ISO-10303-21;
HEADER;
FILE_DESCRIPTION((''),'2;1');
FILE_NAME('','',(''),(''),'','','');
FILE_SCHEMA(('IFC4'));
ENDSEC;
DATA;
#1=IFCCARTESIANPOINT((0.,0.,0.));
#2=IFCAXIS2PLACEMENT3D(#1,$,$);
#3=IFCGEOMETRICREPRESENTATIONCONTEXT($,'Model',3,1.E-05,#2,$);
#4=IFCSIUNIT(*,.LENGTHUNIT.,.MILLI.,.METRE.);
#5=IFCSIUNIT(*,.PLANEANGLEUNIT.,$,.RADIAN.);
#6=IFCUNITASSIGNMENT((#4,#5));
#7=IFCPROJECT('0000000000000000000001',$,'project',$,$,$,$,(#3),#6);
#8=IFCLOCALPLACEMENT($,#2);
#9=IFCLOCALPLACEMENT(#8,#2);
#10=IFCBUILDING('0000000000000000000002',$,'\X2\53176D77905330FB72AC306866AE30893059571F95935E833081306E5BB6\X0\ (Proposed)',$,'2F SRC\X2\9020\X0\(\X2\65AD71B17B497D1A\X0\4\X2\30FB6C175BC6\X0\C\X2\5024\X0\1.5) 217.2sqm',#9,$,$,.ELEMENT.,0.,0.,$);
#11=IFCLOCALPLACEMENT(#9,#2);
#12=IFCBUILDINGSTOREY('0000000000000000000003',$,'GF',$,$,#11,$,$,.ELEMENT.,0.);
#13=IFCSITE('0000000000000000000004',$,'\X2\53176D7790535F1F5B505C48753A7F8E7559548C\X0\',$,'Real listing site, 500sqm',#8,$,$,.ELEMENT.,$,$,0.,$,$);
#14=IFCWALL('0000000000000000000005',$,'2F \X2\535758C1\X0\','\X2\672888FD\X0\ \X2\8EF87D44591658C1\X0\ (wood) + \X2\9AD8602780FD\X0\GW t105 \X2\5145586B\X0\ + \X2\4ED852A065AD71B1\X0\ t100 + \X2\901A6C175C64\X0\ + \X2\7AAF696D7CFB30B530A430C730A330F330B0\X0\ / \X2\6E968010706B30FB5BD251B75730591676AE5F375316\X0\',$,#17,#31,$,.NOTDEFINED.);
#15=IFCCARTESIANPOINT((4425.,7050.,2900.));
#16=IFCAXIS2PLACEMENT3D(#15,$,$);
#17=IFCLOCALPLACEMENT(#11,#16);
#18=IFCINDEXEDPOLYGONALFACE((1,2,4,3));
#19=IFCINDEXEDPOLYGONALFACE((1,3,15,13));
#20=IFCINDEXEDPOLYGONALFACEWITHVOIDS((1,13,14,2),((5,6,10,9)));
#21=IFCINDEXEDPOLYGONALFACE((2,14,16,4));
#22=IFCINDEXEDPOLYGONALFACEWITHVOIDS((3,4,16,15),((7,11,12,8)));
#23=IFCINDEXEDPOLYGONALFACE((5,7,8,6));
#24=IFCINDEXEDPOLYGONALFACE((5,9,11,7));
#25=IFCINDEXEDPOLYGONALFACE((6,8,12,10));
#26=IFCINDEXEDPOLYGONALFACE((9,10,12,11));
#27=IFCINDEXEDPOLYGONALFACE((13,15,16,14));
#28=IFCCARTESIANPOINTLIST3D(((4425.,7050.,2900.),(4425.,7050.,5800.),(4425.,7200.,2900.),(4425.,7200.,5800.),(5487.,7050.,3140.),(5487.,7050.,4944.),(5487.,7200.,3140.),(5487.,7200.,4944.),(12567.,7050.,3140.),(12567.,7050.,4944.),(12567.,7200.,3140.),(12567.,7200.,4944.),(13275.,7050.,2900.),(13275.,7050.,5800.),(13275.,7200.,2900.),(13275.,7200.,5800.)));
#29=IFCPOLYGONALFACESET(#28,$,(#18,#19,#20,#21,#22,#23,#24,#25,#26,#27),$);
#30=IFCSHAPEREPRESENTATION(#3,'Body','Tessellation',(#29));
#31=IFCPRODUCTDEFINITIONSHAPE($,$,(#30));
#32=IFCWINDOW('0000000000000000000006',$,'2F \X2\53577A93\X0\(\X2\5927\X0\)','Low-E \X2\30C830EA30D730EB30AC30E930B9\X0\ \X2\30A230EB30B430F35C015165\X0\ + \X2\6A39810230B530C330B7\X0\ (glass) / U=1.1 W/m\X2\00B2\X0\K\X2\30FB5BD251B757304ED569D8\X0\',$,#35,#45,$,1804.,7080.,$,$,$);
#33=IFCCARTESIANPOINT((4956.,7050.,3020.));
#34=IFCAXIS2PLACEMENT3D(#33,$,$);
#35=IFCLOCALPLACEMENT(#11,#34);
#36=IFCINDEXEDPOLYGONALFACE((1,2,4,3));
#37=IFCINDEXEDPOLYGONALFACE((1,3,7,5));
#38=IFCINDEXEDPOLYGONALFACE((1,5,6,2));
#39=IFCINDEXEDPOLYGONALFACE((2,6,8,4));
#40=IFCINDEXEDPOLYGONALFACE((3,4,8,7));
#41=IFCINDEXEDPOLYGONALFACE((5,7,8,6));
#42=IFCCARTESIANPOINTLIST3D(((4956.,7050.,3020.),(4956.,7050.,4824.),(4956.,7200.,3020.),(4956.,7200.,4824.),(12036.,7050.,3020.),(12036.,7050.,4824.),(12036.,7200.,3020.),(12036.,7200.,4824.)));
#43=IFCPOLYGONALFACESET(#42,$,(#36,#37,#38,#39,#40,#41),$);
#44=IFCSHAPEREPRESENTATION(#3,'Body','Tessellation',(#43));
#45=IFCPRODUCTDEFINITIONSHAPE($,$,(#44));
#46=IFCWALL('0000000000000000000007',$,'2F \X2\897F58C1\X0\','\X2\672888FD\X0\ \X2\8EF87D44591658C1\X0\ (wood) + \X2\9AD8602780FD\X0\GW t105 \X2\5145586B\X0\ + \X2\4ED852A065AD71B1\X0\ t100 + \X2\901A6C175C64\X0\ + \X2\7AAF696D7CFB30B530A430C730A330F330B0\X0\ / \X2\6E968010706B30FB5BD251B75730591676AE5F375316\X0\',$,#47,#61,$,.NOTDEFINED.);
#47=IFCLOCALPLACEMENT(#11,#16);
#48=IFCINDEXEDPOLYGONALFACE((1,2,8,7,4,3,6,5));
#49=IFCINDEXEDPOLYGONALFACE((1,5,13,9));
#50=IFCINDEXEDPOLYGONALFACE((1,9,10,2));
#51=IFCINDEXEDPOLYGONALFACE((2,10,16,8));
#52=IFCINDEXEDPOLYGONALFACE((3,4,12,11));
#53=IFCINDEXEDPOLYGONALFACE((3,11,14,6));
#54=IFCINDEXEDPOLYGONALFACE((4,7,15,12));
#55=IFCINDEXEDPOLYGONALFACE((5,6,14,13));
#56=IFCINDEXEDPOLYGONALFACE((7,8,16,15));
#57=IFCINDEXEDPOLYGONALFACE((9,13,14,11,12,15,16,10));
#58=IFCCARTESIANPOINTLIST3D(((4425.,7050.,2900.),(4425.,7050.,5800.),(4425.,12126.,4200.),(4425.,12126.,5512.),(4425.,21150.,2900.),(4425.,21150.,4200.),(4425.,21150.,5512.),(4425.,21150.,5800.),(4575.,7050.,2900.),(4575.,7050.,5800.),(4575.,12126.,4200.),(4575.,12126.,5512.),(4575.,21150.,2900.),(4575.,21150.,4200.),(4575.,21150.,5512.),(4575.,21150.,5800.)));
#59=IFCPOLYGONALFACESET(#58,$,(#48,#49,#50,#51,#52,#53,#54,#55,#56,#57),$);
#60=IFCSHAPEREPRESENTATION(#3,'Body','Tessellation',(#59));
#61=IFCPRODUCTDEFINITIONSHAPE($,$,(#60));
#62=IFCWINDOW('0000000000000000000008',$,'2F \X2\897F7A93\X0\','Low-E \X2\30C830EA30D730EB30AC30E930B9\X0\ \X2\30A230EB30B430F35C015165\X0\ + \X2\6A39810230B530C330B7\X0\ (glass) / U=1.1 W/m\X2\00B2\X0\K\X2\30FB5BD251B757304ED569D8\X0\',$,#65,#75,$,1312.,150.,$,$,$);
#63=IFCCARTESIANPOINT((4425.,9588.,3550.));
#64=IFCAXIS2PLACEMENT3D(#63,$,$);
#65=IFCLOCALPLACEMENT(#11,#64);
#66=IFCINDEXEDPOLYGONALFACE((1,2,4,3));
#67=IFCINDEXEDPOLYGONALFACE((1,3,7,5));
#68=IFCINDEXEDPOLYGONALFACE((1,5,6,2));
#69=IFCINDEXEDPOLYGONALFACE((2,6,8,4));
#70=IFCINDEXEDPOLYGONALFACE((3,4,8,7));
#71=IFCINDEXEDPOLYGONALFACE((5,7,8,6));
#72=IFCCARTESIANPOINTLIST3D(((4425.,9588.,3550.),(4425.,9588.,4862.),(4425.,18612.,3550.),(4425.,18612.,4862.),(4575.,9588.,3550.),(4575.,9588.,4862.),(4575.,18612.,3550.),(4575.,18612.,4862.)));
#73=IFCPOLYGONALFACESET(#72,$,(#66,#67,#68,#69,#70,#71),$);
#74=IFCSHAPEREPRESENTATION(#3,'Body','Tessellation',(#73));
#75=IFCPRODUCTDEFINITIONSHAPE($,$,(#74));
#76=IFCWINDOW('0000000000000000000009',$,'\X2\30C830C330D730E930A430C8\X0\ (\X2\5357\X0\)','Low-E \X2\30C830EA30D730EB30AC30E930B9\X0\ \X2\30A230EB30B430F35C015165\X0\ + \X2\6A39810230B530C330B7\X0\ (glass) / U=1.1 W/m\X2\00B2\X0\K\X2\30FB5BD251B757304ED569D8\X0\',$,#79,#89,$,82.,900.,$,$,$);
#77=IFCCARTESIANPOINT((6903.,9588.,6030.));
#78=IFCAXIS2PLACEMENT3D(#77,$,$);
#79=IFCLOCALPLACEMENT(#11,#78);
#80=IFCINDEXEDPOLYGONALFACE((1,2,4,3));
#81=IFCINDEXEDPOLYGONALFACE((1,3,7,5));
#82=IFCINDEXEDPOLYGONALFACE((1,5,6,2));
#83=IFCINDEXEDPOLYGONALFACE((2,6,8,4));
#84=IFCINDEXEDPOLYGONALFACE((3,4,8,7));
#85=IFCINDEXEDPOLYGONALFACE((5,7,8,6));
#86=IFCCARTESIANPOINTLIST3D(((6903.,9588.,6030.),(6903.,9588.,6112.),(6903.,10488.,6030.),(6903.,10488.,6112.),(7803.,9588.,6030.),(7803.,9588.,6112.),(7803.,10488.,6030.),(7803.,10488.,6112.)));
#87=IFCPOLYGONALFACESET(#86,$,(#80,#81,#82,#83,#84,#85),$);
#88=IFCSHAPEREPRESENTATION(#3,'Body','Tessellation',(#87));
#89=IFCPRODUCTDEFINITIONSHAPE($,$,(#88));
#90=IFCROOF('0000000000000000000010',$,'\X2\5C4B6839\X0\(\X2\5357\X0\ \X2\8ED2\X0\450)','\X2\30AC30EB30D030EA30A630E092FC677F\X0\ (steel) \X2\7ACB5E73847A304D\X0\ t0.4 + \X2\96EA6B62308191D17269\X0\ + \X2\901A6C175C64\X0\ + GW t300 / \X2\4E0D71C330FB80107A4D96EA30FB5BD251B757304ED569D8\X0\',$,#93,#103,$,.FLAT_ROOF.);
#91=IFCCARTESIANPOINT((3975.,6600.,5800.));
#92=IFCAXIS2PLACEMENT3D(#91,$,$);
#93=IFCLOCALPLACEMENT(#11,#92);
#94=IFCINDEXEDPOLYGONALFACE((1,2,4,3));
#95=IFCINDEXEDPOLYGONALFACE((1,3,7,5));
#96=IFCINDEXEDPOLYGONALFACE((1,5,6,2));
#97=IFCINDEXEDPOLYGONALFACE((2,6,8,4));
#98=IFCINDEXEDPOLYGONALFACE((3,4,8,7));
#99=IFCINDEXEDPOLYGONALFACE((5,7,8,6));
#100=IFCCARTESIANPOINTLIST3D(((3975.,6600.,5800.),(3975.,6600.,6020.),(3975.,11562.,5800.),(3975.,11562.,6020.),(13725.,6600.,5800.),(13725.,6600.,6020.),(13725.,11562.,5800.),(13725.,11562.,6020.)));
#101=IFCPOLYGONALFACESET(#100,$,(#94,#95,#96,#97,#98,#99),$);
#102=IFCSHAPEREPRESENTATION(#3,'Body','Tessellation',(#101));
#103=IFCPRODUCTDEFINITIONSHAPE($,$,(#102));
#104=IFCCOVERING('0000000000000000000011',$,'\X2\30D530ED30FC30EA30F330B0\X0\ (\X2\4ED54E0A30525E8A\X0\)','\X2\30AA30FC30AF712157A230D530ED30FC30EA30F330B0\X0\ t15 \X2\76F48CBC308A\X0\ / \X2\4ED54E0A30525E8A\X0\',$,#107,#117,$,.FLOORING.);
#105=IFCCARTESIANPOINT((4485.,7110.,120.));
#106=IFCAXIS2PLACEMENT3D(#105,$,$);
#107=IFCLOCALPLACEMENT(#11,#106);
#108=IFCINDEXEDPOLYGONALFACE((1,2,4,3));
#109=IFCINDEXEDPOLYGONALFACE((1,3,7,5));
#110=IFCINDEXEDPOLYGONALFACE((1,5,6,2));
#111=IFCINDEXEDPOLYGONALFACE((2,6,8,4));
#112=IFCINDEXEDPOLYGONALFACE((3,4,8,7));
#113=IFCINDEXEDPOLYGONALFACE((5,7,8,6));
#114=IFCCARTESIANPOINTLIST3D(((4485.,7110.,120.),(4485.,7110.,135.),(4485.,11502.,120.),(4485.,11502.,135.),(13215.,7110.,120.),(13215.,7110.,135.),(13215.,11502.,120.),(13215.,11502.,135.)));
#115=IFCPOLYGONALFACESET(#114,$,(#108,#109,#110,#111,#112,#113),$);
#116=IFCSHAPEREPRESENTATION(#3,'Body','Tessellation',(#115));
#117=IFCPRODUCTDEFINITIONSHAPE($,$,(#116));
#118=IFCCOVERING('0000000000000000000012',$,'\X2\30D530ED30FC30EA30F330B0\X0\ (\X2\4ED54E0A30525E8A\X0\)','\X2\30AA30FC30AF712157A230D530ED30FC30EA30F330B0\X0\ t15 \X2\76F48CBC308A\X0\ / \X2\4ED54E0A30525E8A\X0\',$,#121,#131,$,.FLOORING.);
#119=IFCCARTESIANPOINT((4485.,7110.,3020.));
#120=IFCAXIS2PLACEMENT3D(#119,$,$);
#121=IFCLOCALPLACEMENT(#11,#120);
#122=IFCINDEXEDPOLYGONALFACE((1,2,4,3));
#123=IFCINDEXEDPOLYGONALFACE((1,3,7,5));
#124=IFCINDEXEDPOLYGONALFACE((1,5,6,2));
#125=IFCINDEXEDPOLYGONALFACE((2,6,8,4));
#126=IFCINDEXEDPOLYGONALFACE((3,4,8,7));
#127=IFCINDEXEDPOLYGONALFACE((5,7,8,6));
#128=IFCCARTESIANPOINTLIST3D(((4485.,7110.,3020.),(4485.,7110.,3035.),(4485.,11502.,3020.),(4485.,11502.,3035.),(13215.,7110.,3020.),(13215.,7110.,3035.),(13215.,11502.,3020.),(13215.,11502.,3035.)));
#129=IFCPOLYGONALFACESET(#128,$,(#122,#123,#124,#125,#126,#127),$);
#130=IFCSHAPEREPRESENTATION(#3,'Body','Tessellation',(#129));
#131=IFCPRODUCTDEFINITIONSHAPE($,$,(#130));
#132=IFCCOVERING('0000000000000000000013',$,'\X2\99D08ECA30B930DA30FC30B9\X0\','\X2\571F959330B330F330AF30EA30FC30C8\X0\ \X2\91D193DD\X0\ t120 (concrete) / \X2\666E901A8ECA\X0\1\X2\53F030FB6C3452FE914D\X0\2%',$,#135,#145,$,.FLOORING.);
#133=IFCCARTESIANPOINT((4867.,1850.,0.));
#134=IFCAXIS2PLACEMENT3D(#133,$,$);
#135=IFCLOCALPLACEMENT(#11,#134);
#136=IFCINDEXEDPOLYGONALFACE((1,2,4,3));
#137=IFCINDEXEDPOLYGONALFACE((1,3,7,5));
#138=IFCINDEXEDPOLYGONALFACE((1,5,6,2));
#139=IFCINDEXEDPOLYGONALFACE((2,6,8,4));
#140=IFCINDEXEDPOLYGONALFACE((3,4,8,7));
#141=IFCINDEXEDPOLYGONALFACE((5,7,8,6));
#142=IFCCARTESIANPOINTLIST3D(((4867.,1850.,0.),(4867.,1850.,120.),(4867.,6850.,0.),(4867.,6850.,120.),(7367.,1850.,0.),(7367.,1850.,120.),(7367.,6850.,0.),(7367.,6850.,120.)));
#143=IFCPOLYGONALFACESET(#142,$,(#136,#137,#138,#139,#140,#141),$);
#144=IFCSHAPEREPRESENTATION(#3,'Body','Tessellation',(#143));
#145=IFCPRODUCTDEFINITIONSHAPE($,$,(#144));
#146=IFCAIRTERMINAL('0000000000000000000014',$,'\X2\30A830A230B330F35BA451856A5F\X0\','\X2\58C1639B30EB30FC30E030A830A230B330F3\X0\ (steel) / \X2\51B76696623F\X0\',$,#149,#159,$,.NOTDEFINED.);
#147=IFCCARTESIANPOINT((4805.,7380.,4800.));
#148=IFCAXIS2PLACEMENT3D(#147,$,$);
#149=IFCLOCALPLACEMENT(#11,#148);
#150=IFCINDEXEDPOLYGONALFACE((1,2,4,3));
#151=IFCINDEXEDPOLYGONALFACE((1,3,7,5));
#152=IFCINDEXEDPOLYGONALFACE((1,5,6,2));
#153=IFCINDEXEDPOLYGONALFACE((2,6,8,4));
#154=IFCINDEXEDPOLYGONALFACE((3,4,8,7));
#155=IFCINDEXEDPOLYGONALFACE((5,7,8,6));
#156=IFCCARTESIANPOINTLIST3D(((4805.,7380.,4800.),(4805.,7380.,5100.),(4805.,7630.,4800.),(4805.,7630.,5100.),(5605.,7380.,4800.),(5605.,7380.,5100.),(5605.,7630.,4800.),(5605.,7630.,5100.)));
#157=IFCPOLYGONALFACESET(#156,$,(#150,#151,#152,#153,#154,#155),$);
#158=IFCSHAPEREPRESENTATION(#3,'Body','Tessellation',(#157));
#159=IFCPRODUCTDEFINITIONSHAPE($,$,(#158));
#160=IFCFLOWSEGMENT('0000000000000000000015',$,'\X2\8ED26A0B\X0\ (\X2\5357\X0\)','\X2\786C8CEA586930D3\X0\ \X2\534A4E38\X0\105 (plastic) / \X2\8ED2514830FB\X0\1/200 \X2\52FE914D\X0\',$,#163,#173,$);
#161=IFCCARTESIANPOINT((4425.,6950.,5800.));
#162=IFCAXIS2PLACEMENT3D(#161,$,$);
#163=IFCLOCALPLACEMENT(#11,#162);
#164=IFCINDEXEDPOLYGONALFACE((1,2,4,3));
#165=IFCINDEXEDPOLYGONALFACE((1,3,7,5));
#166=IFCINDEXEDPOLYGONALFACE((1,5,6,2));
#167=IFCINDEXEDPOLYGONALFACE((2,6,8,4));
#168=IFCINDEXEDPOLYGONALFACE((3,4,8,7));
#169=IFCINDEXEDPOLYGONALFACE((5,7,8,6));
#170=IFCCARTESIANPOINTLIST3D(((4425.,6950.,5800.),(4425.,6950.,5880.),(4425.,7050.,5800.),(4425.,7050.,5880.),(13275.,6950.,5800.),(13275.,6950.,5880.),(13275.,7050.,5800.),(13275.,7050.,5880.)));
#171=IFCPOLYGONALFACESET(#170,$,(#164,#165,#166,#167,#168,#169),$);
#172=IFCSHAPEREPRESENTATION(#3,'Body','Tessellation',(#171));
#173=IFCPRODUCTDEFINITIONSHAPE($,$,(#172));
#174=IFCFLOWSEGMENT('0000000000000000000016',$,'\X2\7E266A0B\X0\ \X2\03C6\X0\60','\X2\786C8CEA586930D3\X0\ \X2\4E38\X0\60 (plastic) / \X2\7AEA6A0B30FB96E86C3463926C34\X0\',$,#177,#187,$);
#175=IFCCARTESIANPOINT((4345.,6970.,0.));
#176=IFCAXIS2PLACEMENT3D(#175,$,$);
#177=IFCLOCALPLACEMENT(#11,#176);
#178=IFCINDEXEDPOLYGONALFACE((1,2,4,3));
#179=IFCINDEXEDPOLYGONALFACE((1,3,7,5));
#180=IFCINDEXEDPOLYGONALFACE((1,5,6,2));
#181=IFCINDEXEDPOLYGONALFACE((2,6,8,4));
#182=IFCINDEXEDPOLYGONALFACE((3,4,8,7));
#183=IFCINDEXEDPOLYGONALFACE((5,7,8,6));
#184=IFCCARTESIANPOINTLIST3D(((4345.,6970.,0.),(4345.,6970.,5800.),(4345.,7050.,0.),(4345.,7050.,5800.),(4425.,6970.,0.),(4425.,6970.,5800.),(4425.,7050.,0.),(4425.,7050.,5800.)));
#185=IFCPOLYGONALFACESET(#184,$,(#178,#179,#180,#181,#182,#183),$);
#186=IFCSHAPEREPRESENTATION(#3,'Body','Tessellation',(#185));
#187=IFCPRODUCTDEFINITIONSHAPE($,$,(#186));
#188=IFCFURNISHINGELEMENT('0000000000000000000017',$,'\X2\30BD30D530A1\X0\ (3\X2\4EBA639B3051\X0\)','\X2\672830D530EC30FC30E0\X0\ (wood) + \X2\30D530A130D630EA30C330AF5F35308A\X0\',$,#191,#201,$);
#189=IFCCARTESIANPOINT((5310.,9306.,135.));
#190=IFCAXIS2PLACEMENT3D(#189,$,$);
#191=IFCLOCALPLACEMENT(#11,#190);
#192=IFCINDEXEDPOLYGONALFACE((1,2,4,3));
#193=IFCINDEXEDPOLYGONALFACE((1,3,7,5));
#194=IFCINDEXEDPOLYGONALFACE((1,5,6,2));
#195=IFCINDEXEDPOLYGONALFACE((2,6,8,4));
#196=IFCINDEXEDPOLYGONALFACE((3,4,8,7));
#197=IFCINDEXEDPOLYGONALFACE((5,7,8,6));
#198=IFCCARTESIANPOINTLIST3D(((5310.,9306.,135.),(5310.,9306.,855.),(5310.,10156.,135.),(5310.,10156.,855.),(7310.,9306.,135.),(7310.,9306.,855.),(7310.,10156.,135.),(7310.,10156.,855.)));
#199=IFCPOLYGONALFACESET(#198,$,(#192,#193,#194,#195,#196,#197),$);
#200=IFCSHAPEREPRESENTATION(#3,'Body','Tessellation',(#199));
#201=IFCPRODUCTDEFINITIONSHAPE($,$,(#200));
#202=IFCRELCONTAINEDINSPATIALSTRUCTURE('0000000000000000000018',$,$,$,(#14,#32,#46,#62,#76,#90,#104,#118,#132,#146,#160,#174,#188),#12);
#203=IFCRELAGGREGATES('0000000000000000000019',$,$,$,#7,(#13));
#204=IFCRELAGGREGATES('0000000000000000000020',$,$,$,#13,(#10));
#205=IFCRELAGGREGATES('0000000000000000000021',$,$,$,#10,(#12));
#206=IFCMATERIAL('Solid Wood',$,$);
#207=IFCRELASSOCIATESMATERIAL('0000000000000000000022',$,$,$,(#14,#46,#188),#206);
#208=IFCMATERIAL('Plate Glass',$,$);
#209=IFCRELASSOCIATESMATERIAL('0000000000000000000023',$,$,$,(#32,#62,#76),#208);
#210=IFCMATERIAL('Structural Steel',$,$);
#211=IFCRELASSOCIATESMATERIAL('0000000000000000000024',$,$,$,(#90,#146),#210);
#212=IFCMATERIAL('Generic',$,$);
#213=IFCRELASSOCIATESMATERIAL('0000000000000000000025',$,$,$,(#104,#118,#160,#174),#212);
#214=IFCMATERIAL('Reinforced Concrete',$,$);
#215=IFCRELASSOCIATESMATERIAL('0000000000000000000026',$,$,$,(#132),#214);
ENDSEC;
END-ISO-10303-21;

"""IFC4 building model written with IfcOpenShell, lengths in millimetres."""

from ifc_helpers import new_model, si_unit, frame, frame_2d, origin, place, context, project, spatial, rectangle, extrude, material, element, fill, save


model = new_model("IFC4")

# Units and contexts
model_context = context("Model", 3, precision=1e-05, world=origin())
ifc_project = project(units=[si_unit("LENGTHUNIT", "METRE", prefix="MILLI"), si_unit("PLANEANGLEUNIT", "RADIAN")], contexts=[model_context])

# Site, building, storey
site_placement = place(None, origin())
site = spatial("IfcSite", under=ifc_project, at=site_placement, Name="北海道弟子屈町美留和", ObjectType="Real listing site, 500sqm", CompositionType="ELEMENT", RefElevation=0.0)
building_placement = place(site_placement, origin())
building = spatial("IfcBuilding", under=site, at=building_placement, Name="北海道・犬と暮らす土間広めの家 (Proposed)", ObjectType="2F SRC造(断熱等級4・気密C値1.5) 217.2sqm", CompositionType="ELEMENT", ElevationOfRefHeight=0.0, ElevationOfTerrain=0.0)
storey_placement = place(building_placement, origin())
storey = spatial("IfcBuildingStorey", under=building, at=storey_placement, Name="GF", CompositionType="ELEMENT", Elevation=0.0)

# Shared definitions
ifc_material_1 = material(Name="Solid Wood")

# Shared definitions
ifc_material_2 = material(Name="Reinforced Concrete")

# Shared definitions
ifc_material_3 = material(Name="Plate Glass")

# Walls, openings, windows
wall_1_placement = place(storey_placement, frame((4425.0, 7050.0, 2900.0)))
wall_1 = element("IfcWall", 1, at=wall_1_placement, inside=storey, material=ifc_material_1, Name="2F 南壁", Description="木製 軸組外壁 (wood) + 高性能GW t105 充填 + 付加断熱 t100 + 通気層 + 窯業系サイディング / 準耐火・寒冷地外皮強化", PredefinedType="NOTDEFINED", context=model_context, shape_type="SweptSolid", body=[
    extrude(rectangle(XDim=8850.0, YDim=150.0, at=frame_2d((4425.0, 75.0))), frame((4425.0, 7050.0, 2900.0)), (0.0, 0.0, 1.0), 2900.0),
])
opening_1_placement = place(storey_placement, frame((4956.0, 7050.0, 3020.0)))
opening_1 = element("IfcOpeningElement", 2, at=opening_1_placement, cuts=wall_1, PredefinedType="NOTDEFINED", context=model_context, shape_type="SweptSolid", body=[
    extrude(rectangle(XDim=7080.0, YDim=150.0, at=frame_2d((3540.0, 75.0))), frame((4956.0, 7050.0, 3020.0)), (0.0, 0.0, 1.0), 1804.0),
])
window_1_placement = place(storey_placement, frame((4956.0, 7050.0, 3020.0)))
window_1 = element("IfcWindow", 3, at=window_1_placement, inside=storey, material=ifc_material_3, Name="2F 南窓(大)", Description="Low-E トリプルガラス アルゴン封入 + 樹脂サッシ (glass) / U=1.1 W/m²K・寒冷地仕様", OverallHeight=1804.0, OverallWidth=7080.0, context=model_context, shape_type="SweptSolid", body=[
    extrude(rectangle(XDim=7080.0, YDim=150.0, at=frame_2d((3540.0, 75.0))), frame((4956.0, 7050.0, 3020.0)), (0.0, 0.0, 1.0), 1804.0),
])
fill(opening_1, window_1)
wall_2_placement = place(storey_placement, frame((4425.0, 7050.0, 2900.0)))
wall_2 = element("IfcWall", 4, at=wall_2_placement, inside=storey, material=ifc_material_1, Name="2F 西壁", Description="木製 軸組外壁 (wood) + 高性能GW t105 充填 + 付加断熱 t100 + 通気層 + 窯業系サイディング / 準耐火・寒冷地外皮強化", PredefinedType="NOTDEFINED", context=model_context, shape_type="SweptSolid", body=[
    extrude(rectangle(XDim=150.0, YDim=14100.0, at=frame_2d((75.0, 7050.0))), frame((4425.0, 7050.0, 2900.0)), (0.0, 0.0, 1.0), 2900.0),
])
opening_2_placement = place(storey_placement, frame((4425.0, 9588.0, 3550.0)))
opening_2 = element("IfcOpeningElement", 5, at=opening_2_placement, cuts=wall_2, PredefinedType="NOTDEFINED", context=model_context, shape_type="SweptSolid", body=[
    extrude(rectangle(XDim=150.0, YDim=9024.0, at=frame_2d((75.0, 4512.0))), frame((4425.0, 9588.0, 3550.0)), (0.0, 0.0, 1.0), 1312.0),
])
window_2_placement = place(storey_placement, frame((4425.0, 9588.0, 3550.0)))
window_2 = element("IfcWindow", 6, at=window_2_placement, inside=storey, material=ifc_material_3, Name="2F 西窓", Description="Low-E トリプルガラス アルゴン封入 + 樹脂サッシ (glass) / U=1.1 W/m²K・寒冷地仕様", OverallHeight=1312.0, OverallWidth=150.0, context=model_context, shape_type="SweptSolid", body=[
    extrude(rectangle(XDim=150.0, YDim=9024.0, at=frame_2d((75.0, 4512.0))), frame((4425.0, 9588.0, 3550.0)), (0.0, 0.0, 1.0), 1312.0),
])
fill(opening_2, window_2)

# Window
window_3_placement = place(storey_placement, frame((6903.0, 9588.0, 6030.0)))
element("IfcWindow", 7, at=window_3_placement, inside=storey, material=ifc_material_3, Name="トップライト (南)", Description="Low-E トリプルガラス アルゴン封入 + 樹脂サッシ (glass) / U=1.1 W/m²K・寒冷地仕様", OverallHeight=82.0, OverallWidth=900.0, context=model_context, shape_type="SweptSolid", body=[
    extrude(rectangle(XDim=900.0, YDim=900.0, at=frame_2d((450.0, 450.0))), frame((6903.0, 9588.0, 6030.0)), (0.0, 0.0, 1.0), 82.0),
])

# Roof
ifc_material_4 = material(Name="Structural Steel")
for number, where, name in (
    (8, (3975.0, 6600.0, 5800.0), "屋根(南 軒450)"),
):
    element("IfcRoof", number, at=place(storey_placement, frame(where)), inside=storey, material=ifc_material_4, Name=name, Description="ガルバリウム鋼板 (steel) 立平葺き t0.4 + 雪止め金物 + 通気層 + GW t300 / 不燃・耐積雪・寒冷地仕様", PredefinedType="FLAT_ROOF", context=model_context, shape_type="SweptSolid", body=[
        extrude(rectangle(XDim=9750.0, YDim=4962.0, at=frame_2d((4875.0, 2481.0))), frame((3975.0, 6600.0, 5800.0)), (0.0, 0.0, 1.0), 220.0),
    ])

# Coverings
ifc_material_5 = material(Name="Generic")
covering_1_placement = place(storey_placement, frame((4485.0, 7110.0, 120.0)))
element("IfcCovering", 9, at=covering_1_placement, inside=storey, material=ifc_material_5, Name="フローリング (仕上げ床)", Description="オーク無垢フローリング t15 直貼り / 仕上げ床", PredefinedType="FLOORING", context=model_context, shape_type="SweptSolid", body=[
    extrude(rectangle(XDim=8730.0, YDim=4392.0, at=frame_2d((4365.0, 2196.0))), frame((4485.0, 7110.0, 120.0)), (0.0, 0.0, 1.0), 15.0),
])
covering_2_placement = place(storey_placement, frame((4485.0, 7110.0, 3020.0)))
element("IfcCovering", 10, at=covering_2_placement, inside=storey, material=ifc_material_5, Name="フローリング (仕上げ床)", Description="オーク無垢フローリング t15 直貼り / 仕上げ床", PredefinedType="FLOORING", context=model_context, shape_type="SweptSolid", body=[
    extrude(rectangle(XDim=8730.0, YDim=4392.0, at=frame_2d((4365.0, 2196.0))), frame((4485.0, 7110.0, 3020.0)), (0.0, 0.0, 1.0), 15.0),
])
covering_3_placement = place(storey_placement, frame((4867.0, 1850.0, 0.0)))
element("IfcCovering", 11, at=covering_3_placement, inside=storey, material=ifc_material_2, Name="駐車スペース", Description="土間コンクリート 金鏝 t120 (concrete) / 普通車1台・水勾配2%", PredefinedType="FLOORING", context=model_context, shape_type="SweptSolid", body=[
    extrude(rectangle(XDim=2500.0, YDim=5000.0, at=frame_2d((1250.0, 2500.0))), frame((4867.0, 1850.0, 0.0)), (0.0, 0.0, 1.0), 120.0),
])

# Air terminal
air_terminal_placement = place(storey_placement, frame((4805.0, 7380.0, 4800.0)))
element("IfcAirTerminal", 12, at=air_terminal_placement, inside=storey, material=ifc_material_4, Name="エアコン室内機", Description="壁掛ルームエアコン (steel) / 冷暖房", PredefinedType="NOTDEFINED", context=model_context, shape_type="SweptSolid", body=[
    extrude(rectangle(XDim=800.0, YDim=250.0, at=frame_2d((400.0, 125.0))), frame((4805.0, 7380.0, 4800.0)), (0.0, 0.0, 1.0), 300.0),
])

# Flow segments
flow_segment_1_placement = place(storey_placement, frame((4425.0, 6950.0, 5800.0)))
element("IfcFlowSegment", 13, at=flow_segment_1_placement, inside=storey, material=ifc_material_5, Name="軒樋 (南)", Description="硬質塩ビ 半丸105 (plastic) / 軒先・1/200 勾配", context=model_context, shape_type="SweptSolid", body=[
    extrude(rectangle(XDim=8850.0, YDim=100.0, at=frame_2d((4425.0, 50.0))), frame((4425.0, 6950.0, 5800.0)), (0.0, 0.0, 1.0), 80.0),
])
flow_segment_2_placement = place(storey_placement, frame((4345.0, 6970.0, 0.0)))
element("IfcFlowSegment", 14, at=flow_segment_2_placement, inside=storey, material=ifc_material_5, Name="縦樋 φ60", Description="硬質塩ビ 丸60 (plastic) / 竪樋・雨水排水", context=model_context, shape_type="SweptSolid", body=[
    extrude(rectangle(XDim=80.0, YDim=80.0, at=frame_2d((40.0, 40.0))), frame((4345.0, 6970.0, 0.0)), (0.0, 0.0, 1.0), 5800.0),
])

# Furnishing element
furnishing_1_placement = place(storey_placement, frame((5310.0, 9306.0, 135.0)))
element("IfcFurnishingElement", 15, at=furnishing_1_placement, inside=storey, material=ifc_material_1, Name="ソファ (3人掛け)", Description="木フレーム (wood) + ファブリック張り", context=model_context, shape_type="SweptSolid", body=[
    extrude(rectangle(XDim=2000.0, YDim=850.0, at=frame_2d((1000.0, 425.0))), frame((5310.0, 9306.0, 135.0)), (0.0, 0.0, 1.0), 720.0),
])

save(model, "model.ifc")
